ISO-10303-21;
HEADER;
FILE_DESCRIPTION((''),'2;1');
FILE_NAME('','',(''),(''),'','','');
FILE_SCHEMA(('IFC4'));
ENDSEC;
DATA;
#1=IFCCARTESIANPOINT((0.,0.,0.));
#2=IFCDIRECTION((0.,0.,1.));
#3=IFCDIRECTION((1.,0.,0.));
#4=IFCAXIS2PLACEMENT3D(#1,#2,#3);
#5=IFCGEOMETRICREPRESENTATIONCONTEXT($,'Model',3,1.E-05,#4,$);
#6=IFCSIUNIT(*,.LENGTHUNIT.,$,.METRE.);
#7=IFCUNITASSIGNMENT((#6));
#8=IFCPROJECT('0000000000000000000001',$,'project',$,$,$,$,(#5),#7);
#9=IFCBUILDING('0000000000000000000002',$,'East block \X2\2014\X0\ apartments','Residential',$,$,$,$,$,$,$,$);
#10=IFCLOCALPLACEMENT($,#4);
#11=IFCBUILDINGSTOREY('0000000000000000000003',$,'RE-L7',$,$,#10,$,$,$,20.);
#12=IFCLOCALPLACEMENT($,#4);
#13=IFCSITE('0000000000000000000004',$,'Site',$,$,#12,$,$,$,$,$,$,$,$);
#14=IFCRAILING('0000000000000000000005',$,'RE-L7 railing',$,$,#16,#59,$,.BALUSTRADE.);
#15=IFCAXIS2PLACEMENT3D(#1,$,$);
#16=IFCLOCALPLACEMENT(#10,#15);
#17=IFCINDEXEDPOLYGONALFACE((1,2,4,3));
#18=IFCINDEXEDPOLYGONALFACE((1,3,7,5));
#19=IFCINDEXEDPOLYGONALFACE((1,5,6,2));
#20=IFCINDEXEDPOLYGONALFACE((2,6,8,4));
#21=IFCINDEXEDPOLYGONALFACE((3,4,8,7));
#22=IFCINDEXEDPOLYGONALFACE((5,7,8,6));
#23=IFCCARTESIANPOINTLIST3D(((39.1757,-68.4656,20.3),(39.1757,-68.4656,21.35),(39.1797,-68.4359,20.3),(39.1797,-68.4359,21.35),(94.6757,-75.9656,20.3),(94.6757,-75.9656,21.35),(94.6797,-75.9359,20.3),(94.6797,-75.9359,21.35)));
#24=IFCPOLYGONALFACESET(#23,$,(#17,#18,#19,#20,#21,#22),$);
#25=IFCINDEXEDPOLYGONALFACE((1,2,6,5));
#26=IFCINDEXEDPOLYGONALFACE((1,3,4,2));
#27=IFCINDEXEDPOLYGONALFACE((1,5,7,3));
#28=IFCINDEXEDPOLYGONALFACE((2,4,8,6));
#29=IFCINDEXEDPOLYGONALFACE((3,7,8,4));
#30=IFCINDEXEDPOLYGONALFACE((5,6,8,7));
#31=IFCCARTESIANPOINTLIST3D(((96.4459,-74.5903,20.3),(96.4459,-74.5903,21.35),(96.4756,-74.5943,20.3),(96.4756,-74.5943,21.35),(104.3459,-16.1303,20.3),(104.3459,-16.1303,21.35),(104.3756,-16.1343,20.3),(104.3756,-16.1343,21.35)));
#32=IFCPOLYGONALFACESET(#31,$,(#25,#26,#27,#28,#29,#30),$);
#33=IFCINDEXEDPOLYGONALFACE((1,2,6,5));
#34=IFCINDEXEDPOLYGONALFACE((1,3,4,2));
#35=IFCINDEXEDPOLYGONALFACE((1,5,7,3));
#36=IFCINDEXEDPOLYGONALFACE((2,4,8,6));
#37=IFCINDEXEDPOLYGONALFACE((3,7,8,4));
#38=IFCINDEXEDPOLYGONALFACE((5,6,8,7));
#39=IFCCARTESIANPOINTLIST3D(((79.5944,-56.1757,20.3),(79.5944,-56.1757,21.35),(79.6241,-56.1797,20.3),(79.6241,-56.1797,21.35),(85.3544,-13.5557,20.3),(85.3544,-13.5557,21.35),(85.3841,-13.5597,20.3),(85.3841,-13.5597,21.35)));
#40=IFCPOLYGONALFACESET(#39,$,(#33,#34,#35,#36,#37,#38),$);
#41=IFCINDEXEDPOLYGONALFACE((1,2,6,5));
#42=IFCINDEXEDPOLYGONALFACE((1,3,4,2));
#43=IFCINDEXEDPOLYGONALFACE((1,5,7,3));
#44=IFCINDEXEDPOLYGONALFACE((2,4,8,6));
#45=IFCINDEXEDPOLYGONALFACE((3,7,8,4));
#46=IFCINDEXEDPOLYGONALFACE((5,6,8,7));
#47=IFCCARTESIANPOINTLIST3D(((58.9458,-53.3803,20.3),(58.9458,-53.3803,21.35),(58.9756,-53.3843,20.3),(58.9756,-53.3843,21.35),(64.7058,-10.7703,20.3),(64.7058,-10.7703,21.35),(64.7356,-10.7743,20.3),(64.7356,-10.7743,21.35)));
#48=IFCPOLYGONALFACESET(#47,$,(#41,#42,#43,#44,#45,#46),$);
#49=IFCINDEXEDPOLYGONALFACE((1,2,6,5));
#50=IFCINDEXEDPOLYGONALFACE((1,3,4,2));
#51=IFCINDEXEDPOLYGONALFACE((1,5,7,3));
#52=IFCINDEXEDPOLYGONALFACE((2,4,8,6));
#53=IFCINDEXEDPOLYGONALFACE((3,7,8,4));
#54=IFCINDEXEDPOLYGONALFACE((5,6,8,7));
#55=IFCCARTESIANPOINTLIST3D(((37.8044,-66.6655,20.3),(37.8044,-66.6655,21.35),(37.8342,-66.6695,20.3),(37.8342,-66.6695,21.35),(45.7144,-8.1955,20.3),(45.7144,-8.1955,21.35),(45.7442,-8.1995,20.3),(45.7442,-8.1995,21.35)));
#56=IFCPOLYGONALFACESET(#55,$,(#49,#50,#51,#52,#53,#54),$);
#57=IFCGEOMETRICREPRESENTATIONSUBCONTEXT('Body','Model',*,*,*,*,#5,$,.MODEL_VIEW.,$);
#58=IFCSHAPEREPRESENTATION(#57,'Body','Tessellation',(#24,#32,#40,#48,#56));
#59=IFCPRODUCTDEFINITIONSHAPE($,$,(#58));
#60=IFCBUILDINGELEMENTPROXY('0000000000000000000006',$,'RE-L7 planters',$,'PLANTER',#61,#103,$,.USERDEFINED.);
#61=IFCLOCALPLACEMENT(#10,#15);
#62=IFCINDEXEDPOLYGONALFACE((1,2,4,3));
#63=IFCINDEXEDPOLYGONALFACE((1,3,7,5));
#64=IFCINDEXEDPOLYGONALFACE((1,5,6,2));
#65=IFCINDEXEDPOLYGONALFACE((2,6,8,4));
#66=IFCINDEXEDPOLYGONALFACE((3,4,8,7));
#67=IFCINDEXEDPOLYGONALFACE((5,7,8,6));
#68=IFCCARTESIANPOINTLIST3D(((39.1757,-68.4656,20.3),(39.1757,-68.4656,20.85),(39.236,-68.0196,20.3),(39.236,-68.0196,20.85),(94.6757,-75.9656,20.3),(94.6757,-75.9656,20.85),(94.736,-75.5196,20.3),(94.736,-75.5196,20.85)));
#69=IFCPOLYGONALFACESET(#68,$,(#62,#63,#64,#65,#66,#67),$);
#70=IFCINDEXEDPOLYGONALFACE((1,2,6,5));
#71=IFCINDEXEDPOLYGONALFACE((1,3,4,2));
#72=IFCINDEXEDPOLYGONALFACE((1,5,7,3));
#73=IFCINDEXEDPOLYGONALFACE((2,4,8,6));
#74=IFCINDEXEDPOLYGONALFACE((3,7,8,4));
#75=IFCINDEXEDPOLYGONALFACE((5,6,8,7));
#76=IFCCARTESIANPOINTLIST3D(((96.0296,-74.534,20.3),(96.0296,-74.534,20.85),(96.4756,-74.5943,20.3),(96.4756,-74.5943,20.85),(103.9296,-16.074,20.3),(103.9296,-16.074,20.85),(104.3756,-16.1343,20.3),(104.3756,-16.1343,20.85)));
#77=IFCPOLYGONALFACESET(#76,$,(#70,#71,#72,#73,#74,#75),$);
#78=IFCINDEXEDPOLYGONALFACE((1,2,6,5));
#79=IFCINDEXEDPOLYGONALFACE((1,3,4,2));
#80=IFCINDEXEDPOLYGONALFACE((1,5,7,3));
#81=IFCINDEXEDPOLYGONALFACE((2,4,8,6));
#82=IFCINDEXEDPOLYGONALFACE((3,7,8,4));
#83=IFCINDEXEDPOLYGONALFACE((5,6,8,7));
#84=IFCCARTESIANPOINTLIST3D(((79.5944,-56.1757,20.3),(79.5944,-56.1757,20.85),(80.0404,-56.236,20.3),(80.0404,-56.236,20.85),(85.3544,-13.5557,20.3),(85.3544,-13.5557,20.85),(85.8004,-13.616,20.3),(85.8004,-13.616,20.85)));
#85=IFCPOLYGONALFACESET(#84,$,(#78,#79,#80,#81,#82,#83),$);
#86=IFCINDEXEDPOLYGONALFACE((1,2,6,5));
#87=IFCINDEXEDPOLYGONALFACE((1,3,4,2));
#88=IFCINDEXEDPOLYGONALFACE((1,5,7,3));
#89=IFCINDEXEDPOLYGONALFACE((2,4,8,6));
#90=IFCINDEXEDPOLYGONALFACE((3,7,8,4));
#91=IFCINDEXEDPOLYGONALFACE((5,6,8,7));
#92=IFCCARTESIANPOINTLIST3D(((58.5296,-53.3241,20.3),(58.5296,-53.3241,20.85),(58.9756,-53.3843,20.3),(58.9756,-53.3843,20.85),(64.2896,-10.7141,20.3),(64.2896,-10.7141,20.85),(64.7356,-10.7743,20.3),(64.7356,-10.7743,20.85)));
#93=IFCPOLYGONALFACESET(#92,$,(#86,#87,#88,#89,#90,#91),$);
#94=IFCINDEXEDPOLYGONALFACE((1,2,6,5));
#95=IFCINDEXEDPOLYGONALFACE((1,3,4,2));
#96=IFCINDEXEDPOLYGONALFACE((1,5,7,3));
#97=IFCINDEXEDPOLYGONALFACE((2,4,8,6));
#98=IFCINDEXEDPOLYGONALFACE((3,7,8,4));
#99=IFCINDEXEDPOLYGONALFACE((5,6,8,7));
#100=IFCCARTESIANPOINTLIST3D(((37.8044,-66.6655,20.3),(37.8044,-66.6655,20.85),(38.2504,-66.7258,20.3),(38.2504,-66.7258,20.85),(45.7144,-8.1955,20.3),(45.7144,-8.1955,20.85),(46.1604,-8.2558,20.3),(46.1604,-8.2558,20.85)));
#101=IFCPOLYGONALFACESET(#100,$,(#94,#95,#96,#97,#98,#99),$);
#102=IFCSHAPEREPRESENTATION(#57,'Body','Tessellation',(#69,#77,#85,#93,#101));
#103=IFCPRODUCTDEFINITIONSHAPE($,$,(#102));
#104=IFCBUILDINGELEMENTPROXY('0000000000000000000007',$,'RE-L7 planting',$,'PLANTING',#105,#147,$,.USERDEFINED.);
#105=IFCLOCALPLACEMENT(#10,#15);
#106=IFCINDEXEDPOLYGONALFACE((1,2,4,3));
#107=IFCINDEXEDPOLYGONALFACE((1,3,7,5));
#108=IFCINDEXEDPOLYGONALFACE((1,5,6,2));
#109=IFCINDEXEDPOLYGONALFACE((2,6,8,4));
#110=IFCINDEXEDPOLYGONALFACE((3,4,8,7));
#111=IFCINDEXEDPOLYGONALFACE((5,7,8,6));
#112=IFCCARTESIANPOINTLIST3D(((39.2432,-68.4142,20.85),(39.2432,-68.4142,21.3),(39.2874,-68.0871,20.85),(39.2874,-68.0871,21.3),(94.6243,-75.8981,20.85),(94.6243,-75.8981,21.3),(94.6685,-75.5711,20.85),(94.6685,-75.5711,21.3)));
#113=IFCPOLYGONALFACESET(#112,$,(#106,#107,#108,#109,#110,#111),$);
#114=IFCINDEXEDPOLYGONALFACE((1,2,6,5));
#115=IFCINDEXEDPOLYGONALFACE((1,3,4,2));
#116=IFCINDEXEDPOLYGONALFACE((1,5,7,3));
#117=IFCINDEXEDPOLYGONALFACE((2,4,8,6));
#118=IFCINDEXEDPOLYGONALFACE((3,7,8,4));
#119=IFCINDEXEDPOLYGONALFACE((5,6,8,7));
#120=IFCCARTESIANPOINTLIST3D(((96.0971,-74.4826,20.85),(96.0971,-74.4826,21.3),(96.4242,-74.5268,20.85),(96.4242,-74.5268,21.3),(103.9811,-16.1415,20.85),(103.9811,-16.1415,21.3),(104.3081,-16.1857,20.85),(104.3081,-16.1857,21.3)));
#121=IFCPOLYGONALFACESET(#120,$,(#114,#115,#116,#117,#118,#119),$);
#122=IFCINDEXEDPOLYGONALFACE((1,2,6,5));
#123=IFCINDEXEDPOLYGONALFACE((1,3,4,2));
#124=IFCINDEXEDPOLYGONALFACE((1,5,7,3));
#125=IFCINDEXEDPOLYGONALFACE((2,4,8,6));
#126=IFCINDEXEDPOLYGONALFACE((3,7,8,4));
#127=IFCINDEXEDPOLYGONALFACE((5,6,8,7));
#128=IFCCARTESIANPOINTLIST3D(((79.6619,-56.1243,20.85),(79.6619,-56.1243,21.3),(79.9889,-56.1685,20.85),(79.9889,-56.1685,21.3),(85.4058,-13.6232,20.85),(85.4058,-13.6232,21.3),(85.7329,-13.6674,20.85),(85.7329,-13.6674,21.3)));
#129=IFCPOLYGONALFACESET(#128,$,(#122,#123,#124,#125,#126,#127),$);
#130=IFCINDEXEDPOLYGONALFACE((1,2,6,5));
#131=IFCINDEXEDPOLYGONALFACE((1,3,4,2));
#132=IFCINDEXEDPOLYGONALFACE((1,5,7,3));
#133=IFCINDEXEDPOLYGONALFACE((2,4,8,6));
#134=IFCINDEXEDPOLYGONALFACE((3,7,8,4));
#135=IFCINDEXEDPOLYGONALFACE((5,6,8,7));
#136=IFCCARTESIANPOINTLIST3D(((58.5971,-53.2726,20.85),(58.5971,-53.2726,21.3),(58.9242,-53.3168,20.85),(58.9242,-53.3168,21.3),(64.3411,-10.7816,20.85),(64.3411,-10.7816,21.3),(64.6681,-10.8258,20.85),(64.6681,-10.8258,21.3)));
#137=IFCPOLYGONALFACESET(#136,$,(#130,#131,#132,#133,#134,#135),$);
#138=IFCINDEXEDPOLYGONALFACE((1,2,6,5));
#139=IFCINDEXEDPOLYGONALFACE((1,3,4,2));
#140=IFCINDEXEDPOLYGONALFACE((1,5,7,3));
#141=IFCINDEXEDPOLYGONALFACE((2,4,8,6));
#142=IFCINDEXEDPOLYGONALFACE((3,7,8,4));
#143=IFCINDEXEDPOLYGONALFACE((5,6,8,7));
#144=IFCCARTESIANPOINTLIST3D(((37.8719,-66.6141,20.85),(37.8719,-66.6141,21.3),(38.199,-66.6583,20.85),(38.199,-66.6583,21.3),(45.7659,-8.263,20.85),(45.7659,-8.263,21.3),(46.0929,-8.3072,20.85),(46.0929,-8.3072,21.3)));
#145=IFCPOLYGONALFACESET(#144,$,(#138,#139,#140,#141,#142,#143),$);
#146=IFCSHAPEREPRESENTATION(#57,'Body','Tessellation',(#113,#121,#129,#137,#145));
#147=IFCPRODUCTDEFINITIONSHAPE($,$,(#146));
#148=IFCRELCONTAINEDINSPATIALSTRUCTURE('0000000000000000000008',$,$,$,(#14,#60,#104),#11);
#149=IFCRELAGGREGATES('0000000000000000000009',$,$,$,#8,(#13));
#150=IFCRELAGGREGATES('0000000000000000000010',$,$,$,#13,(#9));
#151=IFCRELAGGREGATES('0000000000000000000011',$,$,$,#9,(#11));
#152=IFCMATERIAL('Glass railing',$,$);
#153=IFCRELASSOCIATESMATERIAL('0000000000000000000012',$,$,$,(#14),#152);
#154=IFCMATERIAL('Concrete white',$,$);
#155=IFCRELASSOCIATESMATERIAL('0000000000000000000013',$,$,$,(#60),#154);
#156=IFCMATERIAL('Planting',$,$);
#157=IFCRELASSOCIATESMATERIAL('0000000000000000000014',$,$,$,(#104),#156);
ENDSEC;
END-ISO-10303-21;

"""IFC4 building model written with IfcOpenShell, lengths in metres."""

from ifc_helpers import new_model, si_unit, frame, origin_with_axes, place, context, subcontext, project, spatial, polyline, outline, extrude, material, element, save


model = new_model("IFC4")

# Units and contexts
model_context = context("Model", 3, precision=1e-05, world=origin_with_axes())
body_context = subcontext(model_context, "Body", "Model", "MODEL_VIEW")
ifc_project = project(units=[si_unit("LENGTHUNIT", "METRE")], contexts=[model_context])

# Site, building, storey
site_placement = place(None, origin_with_axes())
site = spatial("IfcSite", under=ifc_project, at=site_placement, Name="Site")
building = spatial("IfcBuilding", under=site, Name="East block — apartments", Description="Residential")
storey_placement = place(None, origin_with_axes())
storey = spatial("IfcBuildingStorey", under=building, at=storey_placement, Name="RE-L7", Elevation=20.0)

# Railing
ifc_material_1 = material(Name="Glass railing")
railing_placement = place(storey_placement, origin_with_axes())
element("IfcRailing", 1, at=railing_placement, inside=storey, material=ifc_material_1, Name="RE-L7 railing", PredefinedType="BALUSTRADE", context=body_context, shape_type="SweptSolid", body=[
    extrude(outline(polyline([(39.1757, -68.4656), (94.6757, -75.9656), (94.6797, -75.9359), (39.1797, -68.4359), (39.1757, -68.4656)])), frame((0.0, 0.0, 20.3), z_axis=(0.0, 0.0, 1.0), x_axis=(1.0, 0.0, 0.0)), (0.0, 0.0, 1.0), 1.05),
    extrude(outline(polyline([(96.4756, -74.5943), (104.3756, -16.1343), (104.3459, -16.1303), (96.4459, -74.5903), (96.4756, -74.5943)])), frame((0.0, 0.0, 20.3), z_axis=(0.0, 0.0, 1.0), x_axis=(1.0, 0.0, 0.0)), (0.0, 0.0, 1.0), 1.05),
    extrude(outline(polyline([(85.3544, -13.5557), (79.5944, -56.1757), (79.6241, -56.1797), (85.3841, -13.5597), (85.3544, -13.5557)])), frame((0.0, 0.0, 20.3), z_axis=(0.0, 0.0, 1.0), x_axis=(1.0, 0.0, 0.0)), (0.0, 0.0, 1.0), 1.05),
    extrude(outline(polyline([(58.9756, -53.3843), (64.7356, -10.7743), (64.7058, -10.7703), (58.9458, -53.3803), (58.9756, -53.3843)])), frame((0.0, 0.0, 20.3), z_axis=(0.0, 0.0, 1.0), x_axis=(1.0, 0.0, 0.0)), (0.0, 0.0, 1.0), 1.05),
    extrude(outline(polyline([(45.7144, -8.1955), (37.8044, -66.6655), (37.8342, -66.6695), (45.7442, -8.1995), (45.7144, -8.1955)])), frame((0.0, 0.0, 20.3), z_axis=(0.0, 0.0, 1.0), x_axis=(1.0, 0.0, 0.0)), (0.0, 0.0, 1.0), 1.05),
])

# Building element proxies
ifc_material_2 = material(Name="Concrete white")
proxy_1_placement = place(storey_placement, origin_with_axes())
element("IfcBuildingElementProxy", 2, at=proxy_1_placement, inside=storey, material=ifc_material_2, Name="RE-L7 planters", ObjectType="PLANTER", PredefinedType="USERDEFINED", context=body_context, shape_type="SweptSolid", body=[
    extrude(outline(polyline([(39.1757, -68.4656), (94.6757, -75.9656), (94.736, -75.5196), (39.236, -68.0196), (39.1757, -68.4656)])), frame((0.0, 0.0, 20.3), z_axis=(0.0, 0.0, 1.0), x_axis=(1.0, 0.0, 0.0)), (0.0, 0.0, 1.0), 0.55),
    extrude(outline(polyline([(96.4756, -74.5943), (104.3756, -16.1343), (103.9296, -16.074), (96.0296, -74.534), (96.4756, -74.5943)])), frame((0.0, 0.0, 20.3), z_axis=(0.0, 0.0, 1.0), x_axis=(1.0, 0.0, 0.0)), (0.0, 0.0, 1.0), 0.55),
    extrude(outline(polyline([(85.3544, -13.5557), (79.5944, -56.1757), (80.0404, -56.236), (85.8004, -13.616), (85.3544, -13.5557)])), frame((0.0, 0.0, 20.3), z_axis=(0.0, 0.0, 1.0), x_axis=(1.0, 0.0, 0.0)), (0.0, 0.0, 1.0), 0.55),
    extrude(outline(polyline([(58.9756, -53.3843), (64.7356, -10.7743), (64.2896, -10.7141), (58.5296, -53.3241), (58.9756, -53.3843)])), frame((0.0, 0.0, 20.3), z_axis=(0.0, 0.0, 1.0), x_axis=(1.0, 0.0, 0.0)), (0.0, 0.0, 1.0), 0.55),
    extrude(outline(polyline([(45.7144, -8.1955), (37.8044, -66.6655), (38.2504, -66.7258), (46.1604, -8.2558), (45.7144, -8.1955)])), frame((0.0, 0.0, 20.3), z_axis=(0.0, 0.0, 1.0), x_axis=(1.0, 0.0, 0.0)), (0.0, 0.0, 1.0), 0.55),
])
ifc_material_3 = material(Name="Planting")
proxy_2_placement = place(storey_placement, origin_with_axes())
element("IfcBuildingElementProxy", 3, at=proxy_2_placement, inside=storey, material=ifc_material_3, Name="RE-L7 planting", ObjectType="PLANTING", PredefinedType="USERDEFINED", context=body_context, shape_type="SweptSolid", body=[
    extrude(outline(polyline([(39.2432, -68.4142), (94.6243, -75.8981), (94.6685, -75.5711), (39.2874, -68.0871), (39.2432, -68.4142)])), frame((0.0, 0.0, 20.85), z_axis=(0.0, 0.0, 1.0), x_axis=(1.0, 0.0, 0.0)), (0.0, 0.0, 1.0), 0.45),
    extrude(outline(polyline([(96.4242, -74.5268), (104.3081, -16.1857), (103.9811, -16.1415), (96.0971, -74.4826), (96.4242, -74.5268)])), frame((0.0, 0.0, 20.85), z_axis=(0.0, 0.0, 1.0), x_axis=(1.0, 0.0, 0.0)), (0.0, 0.0, 1.0), 0.45),
    extrude(outline(polyline([(85.4058, -13.6232), (79.6619, -56.1243), (79.9889, -56.1685), (85.7329, -13.6674), (85.4058, -13.6232)])), frame((0.0, 0.0, 20.85), z_axis=(0.0, 0.0, 1.0), x_axis=(1.0, 0.0, 0.0)), (0.0, 0.0, 1.0), 0.45),
    extrude(outline(polyline([(58.9242, -53.3168), (64.6681, -10.8258), (64.3411, -10.7816), (58.5971, -53.2726), (58.9242, -53.3168)])), frame((0.0, 0.0, 20.85), z_axis=(0.0, 0.0, 1.0), x_axis=(1.0, 0.0, 0.0)), (0.0, 0.0, 1.0), 0.45),
    extrude(outline(polyline([(45.7659, -8.263), (37.8719, -66.6141), (38.199, -66.6583), (46.0929, -8.3072), (45.7659, -8.263)])), frame((0.0, 0.0, 20.85), z_axis=(0.0, 0.0, 1.0), x_axis=(1.0, 0.0, 0.0)), (0.0, 0.0, 1.0), 0.45),
])

save(model, "model.ifc")
